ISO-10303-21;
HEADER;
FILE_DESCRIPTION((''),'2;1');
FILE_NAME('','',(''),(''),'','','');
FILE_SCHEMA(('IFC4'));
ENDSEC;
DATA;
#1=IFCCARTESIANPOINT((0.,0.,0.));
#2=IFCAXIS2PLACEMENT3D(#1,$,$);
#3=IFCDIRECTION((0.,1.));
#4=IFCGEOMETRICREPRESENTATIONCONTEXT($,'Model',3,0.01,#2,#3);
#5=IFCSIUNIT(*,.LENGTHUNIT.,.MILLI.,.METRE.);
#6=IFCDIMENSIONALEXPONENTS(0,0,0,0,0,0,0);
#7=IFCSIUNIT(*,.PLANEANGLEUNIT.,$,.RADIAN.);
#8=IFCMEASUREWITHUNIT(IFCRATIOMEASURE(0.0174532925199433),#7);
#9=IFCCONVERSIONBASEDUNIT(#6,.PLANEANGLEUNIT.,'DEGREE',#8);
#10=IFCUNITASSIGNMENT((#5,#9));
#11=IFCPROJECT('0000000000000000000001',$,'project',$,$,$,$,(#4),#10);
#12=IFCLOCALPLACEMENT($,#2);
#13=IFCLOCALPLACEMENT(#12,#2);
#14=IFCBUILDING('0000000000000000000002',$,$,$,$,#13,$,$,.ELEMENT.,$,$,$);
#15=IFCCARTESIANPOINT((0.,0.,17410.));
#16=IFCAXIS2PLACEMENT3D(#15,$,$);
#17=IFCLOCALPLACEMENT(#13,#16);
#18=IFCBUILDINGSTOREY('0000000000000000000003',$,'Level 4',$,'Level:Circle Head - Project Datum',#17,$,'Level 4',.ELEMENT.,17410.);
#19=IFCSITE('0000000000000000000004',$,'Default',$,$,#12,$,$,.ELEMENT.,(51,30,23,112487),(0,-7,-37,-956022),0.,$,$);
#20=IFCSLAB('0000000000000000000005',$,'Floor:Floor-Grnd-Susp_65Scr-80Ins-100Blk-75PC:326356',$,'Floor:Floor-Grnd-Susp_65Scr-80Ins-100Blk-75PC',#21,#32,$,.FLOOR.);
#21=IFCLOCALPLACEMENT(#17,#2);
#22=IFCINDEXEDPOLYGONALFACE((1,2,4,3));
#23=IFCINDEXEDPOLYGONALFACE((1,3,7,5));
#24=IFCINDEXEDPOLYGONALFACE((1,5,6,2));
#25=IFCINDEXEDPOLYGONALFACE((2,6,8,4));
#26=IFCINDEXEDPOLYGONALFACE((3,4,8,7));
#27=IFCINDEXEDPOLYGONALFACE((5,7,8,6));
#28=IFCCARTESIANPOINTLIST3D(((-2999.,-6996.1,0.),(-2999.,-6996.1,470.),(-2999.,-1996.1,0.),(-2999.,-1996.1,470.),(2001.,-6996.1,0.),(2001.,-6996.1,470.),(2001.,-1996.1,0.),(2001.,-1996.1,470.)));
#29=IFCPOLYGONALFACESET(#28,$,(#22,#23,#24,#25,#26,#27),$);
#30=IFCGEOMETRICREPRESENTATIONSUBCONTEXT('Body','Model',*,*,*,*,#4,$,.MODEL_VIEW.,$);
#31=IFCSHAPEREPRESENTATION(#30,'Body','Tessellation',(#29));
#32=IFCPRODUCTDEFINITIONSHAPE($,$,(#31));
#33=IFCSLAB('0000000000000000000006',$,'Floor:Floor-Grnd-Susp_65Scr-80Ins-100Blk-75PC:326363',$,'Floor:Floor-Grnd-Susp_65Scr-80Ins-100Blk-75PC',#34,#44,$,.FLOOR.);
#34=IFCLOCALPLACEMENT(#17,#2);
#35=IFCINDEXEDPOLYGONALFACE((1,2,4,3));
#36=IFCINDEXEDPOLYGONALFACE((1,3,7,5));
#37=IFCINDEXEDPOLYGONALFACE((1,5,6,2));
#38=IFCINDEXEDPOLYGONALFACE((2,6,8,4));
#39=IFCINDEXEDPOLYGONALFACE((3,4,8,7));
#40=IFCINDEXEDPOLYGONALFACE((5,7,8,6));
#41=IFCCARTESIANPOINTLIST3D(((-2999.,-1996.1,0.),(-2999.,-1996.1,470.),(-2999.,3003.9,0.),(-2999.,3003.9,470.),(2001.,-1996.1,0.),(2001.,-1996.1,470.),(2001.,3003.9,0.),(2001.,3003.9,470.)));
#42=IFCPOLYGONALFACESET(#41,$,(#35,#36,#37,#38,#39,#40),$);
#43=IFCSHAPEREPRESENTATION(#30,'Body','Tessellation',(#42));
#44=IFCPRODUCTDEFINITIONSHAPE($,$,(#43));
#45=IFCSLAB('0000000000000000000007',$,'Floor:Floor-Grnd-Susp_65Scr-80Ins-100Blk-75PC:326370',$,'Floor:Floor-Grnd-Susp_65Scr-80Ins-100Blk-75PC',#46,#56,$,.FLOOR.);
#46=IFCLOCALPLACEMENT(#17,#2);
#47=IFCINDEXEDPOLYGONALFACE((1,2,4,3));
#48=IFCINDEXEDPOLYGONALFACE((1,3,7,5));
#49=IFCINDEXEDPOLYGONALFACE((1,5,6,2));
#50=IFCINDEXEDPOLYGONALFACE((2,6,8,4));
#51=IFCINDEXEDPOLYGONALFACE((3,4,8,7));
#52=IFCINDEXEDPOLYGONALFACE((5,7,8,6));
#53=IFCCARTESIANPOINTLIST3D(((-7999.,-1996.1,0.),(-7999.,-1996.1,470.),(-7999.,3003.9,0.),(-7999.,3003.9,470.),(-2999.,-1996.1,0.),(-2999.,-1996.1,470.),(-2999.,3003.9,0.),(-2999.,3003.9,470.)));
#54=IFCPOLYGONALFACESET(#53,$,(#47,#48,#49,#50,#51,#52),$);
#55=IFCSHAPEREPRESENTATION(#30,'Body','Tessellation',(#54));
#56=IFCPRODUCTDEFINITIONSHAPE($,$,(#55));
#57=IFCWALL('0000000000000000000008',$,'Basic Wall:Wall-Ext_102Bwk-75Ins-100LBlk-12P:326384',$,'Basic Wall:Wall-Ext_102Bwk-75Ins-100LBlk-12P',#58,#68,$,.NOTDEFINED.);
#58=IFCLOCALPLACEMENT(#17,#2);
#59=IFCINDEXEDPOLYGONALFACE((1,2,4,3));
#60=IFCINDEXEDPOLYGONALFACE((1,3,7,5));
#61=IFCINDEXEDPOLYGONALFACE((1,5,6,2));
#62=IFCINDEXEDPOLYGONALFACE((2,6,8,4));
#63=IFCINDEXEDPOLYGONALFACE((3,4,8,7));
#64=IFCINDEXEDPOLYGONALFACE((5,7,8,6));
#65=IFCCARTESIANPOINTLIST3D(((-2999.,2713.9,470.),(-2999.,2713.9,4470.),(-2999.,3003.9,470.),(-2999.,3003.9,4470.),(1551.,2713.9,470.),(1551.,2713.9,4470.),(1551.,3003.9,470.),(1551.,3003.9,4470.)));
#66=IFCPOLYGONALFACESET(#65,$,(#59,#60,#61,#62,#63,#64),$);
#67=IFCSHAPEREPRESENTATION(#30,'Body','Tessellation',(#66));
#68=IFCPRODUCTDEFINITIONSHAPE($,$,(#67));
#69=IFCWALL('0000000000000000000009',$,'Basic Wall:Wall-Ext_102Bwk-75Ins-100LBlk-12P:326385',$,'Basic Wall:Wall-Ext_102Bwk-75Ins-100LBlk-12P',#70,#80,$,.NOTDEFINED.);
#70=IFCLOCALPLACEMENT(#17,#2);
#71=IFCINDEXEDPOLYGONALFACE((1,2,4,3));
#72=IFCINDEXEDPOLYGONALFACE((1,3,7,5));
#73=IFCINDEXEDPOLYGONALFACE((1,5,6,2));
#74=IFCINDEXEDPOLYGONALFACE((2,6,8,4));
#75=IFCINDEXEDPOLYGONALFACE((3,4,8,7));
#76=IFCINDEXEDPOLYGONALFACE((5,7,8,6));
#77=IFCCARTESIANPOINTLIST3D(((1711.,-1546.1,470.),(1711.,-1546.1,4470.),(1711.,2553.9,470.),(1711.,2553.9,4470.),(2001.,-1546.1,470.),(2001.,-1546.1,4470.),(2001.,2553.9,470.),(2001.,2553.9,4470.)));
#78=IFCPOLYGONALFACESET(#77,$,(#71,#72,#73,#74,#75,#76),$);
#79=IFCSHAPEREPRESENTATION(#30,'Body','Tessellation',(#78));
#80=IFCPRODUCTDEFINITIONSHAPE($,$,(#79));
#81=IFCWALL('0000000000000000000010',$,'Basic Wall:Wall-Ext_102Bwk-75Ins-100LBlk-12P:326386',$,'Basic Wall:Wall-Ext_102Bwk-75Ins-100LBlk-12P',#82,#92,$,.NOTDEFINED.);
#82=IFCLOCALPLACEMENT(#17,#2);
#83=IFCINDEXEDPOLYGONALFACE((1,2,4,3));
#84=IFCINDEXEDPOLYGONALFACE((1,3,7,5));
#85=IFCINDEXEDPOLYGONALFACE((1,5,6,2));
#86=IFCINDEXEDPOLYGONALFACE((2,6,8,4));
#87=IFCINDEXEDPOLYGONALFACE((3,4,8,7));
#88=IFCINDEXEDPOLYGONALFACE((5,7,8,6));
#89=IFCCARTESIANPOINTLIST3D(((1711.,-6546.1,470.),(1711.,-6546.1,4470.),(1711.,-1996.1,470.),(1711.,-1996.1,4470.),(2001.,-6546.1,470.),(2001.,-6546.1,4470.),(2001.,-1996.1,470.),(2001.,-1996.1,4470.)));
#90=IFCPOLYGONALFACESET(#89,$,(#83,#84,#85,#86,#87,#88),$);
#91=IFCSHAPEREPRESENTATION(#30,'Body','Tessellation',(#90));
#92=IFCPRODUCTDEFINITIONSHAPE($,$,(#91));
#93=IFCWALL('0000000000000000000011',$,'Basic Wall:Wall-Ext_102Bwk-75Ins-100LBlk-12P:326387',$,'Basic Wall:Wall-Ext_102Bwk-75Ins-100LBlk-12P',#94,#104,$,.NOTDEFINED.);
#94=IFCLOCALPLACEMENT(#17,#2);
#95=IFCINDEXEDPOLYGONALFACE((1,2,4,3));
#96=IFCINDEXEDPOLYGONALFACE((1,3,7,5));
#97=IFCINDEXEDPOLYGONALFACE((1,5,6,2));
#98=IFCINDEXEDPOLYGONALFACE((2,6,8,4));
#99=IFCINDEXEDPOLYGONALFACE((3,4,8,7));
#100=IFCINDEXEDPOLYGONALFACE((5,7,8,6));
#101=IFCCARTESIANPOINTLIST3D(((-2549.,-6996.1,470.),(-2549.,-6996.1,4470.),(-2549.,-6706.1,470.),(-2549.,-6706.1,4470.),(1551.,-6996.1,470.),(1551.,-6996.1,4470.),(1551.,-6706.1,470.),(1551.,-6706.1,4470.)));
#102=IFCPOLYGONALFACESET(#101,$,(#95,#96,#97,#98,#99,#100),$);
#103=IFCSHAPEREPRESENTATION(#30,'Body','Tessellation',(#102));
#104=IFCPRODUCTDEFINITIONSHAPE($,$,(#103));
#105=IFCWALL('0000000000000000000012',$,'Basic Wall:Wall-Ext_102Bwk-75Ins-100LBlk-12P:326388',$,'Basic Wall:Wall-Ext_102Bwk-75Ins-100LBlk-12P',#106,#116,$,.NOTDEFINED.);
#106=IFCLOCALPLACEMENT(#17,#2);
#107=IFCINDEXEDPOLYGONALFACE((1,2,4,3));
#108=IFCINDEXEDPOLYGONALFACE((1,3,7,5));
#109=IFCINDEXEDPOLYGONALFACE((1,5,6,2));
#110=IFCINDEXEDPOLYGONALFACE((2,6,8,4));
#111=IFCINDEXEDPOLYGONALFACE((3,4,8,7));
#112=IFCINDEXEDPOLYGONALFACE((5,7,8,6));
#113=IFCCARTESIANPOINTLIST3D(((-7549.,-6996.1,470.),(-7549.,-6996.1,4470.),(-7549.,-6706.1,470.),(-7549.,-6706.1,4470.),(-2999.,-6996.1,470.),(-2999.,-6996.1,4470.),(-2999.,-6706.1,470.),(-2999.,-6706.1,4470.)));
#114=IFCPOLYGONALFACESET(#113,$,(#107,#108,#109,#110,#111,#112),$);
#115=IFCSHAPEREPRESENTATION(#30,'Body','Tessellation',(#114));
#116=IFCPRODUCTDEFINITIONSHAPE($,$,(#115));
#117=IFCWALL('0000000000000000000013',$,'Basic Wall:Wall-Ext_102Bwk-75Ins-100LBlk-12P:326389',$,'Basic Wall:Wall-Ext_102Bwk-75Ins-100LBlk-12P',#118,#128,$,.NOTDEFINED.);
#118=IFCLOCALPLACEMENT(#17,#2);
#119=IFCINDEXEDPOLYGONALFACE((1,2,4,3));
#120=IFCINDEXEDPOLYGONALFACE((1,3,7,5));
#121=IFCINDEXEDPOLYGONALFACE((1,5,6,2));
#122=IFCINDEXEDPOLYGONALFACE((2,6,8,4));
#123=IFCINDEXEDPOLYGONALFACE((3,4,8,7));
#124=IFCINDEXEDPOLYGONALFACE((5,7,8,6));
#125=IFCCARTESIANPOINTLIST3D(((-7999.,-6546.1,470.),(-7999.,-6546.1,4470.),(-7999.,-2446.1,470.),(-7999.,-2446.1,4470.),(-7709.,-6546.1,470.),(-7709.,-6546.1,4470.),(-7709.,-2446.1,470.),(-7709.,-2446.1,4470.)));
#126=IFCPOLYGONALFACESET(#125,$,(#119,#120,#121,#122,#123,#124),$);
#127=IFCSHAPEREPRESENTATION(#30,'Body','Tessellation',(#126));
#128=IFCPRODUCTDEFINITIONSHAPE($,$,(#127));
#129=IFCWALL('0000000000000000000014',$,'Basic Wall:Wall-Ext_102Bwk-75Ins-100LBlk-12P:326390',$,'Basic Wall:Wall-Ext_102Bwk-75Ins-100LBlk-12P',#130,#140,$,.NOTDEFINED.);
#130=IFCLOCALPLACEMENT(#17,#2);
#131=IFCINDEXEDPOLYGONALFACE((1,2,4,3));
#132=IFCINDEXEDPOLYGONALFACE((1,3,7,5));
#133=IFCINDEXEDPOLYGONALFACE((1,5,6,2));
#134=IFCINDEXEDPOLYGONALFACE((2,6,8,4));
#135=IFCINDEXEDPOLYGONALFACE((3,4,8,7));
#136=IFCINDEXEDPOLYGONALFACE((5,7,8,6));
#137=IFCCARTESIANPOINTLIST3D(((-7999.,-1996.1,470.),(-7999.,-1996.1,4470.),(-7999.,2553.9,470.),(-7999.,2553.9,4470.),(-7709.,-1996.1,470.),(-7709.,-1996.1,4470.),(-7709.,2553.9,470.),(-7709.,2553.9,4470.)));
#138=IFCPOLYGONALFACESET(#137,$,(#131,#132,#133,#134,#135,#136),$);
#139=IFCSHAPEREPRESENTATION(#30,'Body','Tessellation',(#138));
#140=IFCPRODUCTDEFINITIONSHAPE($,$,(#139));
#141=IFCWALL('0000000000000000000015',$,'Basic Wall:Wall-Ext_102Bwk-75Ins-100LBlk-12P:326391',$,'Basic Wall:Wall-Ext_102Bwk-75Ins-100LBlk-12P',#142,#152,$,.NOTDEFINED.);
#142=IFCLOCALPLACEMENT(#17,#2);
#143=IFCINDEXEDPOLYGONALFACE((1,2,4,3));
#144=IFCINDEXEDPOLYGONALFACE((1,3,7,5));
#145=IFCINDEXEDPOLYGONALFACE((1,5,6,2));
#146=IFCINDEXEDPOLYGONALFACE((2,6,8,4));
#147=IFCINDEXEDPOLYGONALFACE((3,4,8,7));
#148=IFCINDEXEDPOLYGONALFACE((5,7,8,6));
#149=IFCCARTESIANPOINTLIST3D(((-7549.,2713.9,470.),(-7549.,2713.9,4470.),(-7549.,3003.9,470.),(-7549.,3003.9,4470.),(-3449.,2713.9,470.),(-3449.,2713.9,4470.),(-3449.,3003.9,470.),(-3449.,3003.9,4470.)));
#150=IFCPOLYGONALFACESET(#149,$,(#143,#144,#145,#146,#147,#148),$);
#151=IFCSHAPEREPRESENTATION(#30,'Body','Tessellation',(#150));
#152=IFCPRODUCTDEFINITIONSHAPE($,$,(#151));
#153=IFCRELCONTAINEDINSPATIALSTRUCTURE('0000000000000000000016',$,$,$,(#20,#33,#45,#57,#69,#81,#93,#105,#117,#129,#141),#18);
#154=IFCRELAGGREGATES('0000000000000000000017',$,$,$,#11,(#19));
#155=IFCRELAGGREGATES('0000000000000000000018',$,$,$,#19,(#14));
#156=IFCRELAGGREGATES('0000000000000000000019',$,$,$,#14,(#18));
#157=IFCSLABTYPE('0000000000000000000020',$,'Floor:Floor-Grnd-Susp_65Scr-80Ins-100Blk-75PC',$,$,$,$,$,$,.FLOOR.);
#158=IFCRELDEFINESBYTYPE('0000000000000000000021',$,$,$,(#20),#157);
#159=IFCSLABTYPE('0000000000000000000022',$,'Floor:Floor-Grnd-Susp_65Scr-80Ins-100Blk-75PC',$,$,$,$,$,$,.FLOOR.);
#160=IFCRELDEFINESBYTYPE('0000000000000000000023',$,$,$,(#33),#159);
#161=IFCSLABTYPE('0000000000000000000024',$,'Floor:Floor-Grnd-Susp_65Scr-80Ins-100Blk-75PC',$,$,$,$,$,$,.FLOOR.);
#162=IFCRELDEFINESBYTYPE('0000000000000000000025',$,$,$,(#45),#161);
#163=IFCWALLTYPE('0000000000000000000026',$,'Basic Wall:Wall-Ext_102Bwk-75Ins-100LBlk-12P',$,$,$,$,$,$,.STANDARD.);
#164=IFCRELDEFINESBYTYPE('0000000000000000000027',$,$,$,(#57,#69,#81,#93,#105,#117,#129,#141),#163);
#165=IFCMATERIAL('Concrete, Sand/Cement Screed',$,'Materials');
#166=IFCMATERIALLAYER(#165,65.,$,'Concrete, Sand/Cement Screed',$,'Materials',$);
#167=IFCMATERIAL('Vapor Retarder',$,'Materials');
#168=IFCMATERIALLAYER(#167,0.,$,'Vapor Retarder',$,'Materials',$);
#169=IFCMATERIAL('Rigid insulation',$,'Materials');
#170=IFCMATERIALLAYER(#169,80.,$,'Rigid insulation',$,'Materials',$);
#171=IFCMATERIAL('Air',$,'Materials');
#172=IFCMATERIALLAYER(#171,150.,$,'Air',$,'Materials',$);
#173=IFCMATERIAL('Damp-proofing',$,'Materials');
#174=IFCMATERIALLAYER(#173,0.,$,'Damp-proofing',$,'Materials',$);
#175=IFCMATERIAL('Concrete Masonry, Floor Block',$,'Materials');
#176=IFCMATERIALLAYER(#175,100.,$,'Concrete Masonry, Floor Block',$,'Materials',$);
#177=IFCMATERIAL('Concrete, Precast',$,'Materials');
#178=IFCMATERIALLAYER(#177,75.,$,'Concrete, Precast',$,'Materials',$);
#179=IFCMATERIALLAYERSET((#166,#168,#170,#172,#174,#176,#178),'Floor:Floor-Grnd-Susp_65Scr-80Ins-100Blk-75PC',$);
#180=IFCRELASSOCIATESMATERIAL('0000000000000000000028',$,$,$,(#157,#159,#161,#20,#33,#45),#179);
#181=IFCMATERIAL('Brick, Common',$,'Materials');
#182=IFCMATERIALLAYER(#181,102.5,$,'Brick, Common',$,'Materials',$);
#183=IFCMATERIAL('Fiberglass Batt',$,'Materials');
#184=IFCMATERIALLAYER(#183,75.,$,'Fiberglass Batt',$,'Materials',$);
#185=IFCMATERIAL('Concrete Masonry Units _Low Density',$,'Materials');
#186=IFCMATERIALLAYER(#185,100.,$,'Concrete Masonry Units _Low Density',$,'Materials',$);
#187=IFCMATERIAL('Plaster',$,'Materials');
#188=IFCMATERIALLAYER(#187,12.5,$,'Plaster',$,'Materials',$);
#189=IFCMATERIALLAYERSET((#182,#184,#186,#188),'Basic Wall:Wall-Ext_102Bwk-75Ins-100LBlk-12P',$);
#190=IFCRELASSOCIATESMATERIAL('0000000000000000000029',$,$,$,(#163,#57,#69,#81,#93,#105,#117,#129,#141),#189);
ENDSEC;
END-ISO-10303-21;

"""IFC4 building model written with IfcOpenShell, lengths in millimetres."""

from ifc_helpers import new_model, entity, si_unit, converted_unit, direction, frame, frame_2d, origin, origin_2d_with_axis, place, context, subcontext, project, spatial, rectangle, extrude, material, layer, layer_set, layer_usage, type_object, element, save


model = new_model("IFC4")

# Units and contexts
model_context = context("Model", 3, precision=0.01, world=origin(), true_north=direction((0.0, 1.0)))
body_context = subcontext(model_context, "Body", "Model", "MODEL_VIEW")
ifc_project = project(units=[si_unit("LENGTHUNIT", "METRE", prefix="MILLI"), converted_unit("PLANEANGLEUNIT", "DEGREE", entity("IfcRatioMeasure", 0.0174532925199433), si_unit("PLANEANGLEUNIT", "RADIAN"), dimensions=[0, 0, 0, 0, 0, 0, 0])], contexts=[model_context])

# Site, building, storey
site_placement = place(None, origin())
site = spatial("IfcSite", under=ifc_project, at=site_placement, Name="Default", CompositionType="ELEMENT", RefLatitude=(51, 30, 23, 112487), RefLongitude=(0, -7, -37, -956022), RefElevation=0.0)
building_placement = place(site_placement, origin())
building = spatial("IfcBuilding", under=site, at=building_placement, CompositionType="ELEMENT")
storey_placement = place(building_placement, frame((0.0, 0.0, 17410.0)))
storey = spatial("IfcBuildingStorey", under=building, at=storey_placement, Name="Level 4", ObjectType="Level:Circle Head - Project Datum", LongName="Level 4", CompositionType="ELEMENT", Elevation=17410.0)

# Slabs
ifc_material_1 = material(Name="Concrete, Sand/Cement Screed", Category="Materials")
ifc_layer_1 = layer(ifc_material_1, 65.0, Name="Concrete, Sand/Cement Screed", Category="Materials")
ifc_material_2 = material(Name="Vapor Retarder", Category="Materials")
ifc_layer_2 = layer(ifc_material_2, 0.0, Name="Vapor Retarder", Category="Materials")
ifc_material_3 = material(Name="Rigid insulation", Category="Materials")
ifc_layer_3 = layer(ifc_material_3, 80.0, Name="Rigid insulation", Category="Materials")
ifc_material_4 = material(Name="Air", Category="Materials")
ifc_layer_4 = layer(ifc_material_4, 150.0, Name="Air", Category="Materials")
ifc_material_5 = material(Name="Damp-proofing", Category="Materials")
ifc_layer_5 = layer(ifc_material_5, 0.0, Name="Damp-proofing", Category="Materials")
ifc_material_6 = material(Name="Concrete Masonry, Floor Block", Category="Materials")
ifc_layer_6 = layer(ifc_material_6, 100.0, Name="Concrete Masonry, Floor Block", Category="Materials")
ifc_material_7 = material(Name="Concrete, Precast", Category="Materials")
ifc_layer_7 = layer(ifc_material_7, 75.0, Name="Concrete, Precast", Category="Materials")
ifc_layer_set_1 = layer_set([ifc_layer_1, ifc_layer_2, ifc_layer_3, ifc_layer_4, ifc_layer_5, ifc_layer_6, ifc_layer_7], Name="Floor:Floor-Grnd-Susp_65Scr-80Ins-100Blk-75PC")
ifc_layer_usage_1 = layer_usage(ifc_layer_set_1, "AXIS3", "POSITIVE", 0.0)
slab_type_1 = type_object("IfcSlabType", Name="Floor:Floor-Grnd-Susp_65Scr-80Ins-100Blk-75PC", PredefinedType="FLOOR", material=ifc_layer_set_1)
slab_1_placement = place(storey_placement, origin())
element("IfcSlab", 1, at=slab_1_placement, inside=storey, type_object=slab_type_1, material=ifc_layer_usage_1, Name="Floor:Floor-Grnd-Susp_65Scr-80Ins-100Blk-75PC:326356", ObjectType="Floor:Floor-Grnd-Susp_65Scr-80Ins-100Blk-75PC", PredefinedType="FLOOR", context=body_context, shape_type="SweptSolid", body=[
    extrude(rectangle(XDim=5000.0, YDim=5000.0, at=frame_2d((0.0, 0.0), x_axis=(1.0, 0.0))), frame((-499.0, -4496.1, 470.0), z_axis=(0.0, 0.0, -1.0), x_axis=(0.0, 1.0, 0.0)), (0.0, 0.0, 1.0), 470.0),
])
ifc_layer_usage_2 = layer_usage(ifc_layer_set_1, "AXIS3", "POSITIVE", 0.0)
slab_type_2 = type_object("IfcSlabType", Name="Floor:Floor-Grnd-Susp_65Scr-80Ins-100Blk-75PC", PredefinedType="FLOOR", material=ifc_layer_set_1)
slab_2_placement = place(storey_placement, origin())
element("IfcSlab", 2, at=slab_2_placement, inside=storey, type_object=slab_type_2, material=ifc_layer_usage_2, Name="Floor:Floor-Grnd-Susp_65Scr-80Ins-100Blk-75PC:326363", ObjectType="Floor:Floor-Grnd-Susp_65Scr-80Ins-100Blk-75PC", PredefinedType="FLOOR", context=body_context, shape_type="SweptSolid", body=[
    extrude(rectangle(XDim=5000.0, YDim=5000.0, at=origin_2d_with_axis()), frame((-499.0, 503.9, 470.0), z_axis=(0.0, 0.0, -1.0), x_axis=(0.0, 1.0, 0.0)), (0.0, 0.0, 1.0), 470.0),
])
ifc_layer_usage_3 = layer_usage(ifc_layer_set_1, "AXIS3", "POSITIVE", 0.0)
slab_type_3 = type_object("IfcSlabType", Name="Floor:Floor-Grnd-Susp_65Scr-80Ins-100Blk-75PC", PredefinedType="FLOOR", material=ifc_layer_set_1)
slab_3_placement = place(storey_placement, origin())
element("IfcSlab", 3, at=slab_3_placement, inside=storey, type_object=slab_type_3, material=ifc_layer_usage_3, Name="Floor:Floor-Grnd-Susp_65Scr-80Ins-100Blk-75PC:326370", ObjectType="Floor:Floor-Grnd-Susp_65Scr-80Ins-100Blk-75PC", PredefinedType="FLOOR", context=body_context, shape_type="SweptSolid", body=[
    extrude(rectangle(XDim=5000.0, YDim=5000.0, at=origin_2d_with_axis()), frame((-5499.0, 503.9, 470.0), z_axis=(0.0, 0.0, -1.0), x_axis=(0.0, 1.0, 0.0)), (0.0, 0.0, 1.0), 470.0),
])

# Walls
ifc_material_8 = material(Name="Brick, Common", Category="Materials")
ifc_layer_8 = layer(ifc_material_8, 102.5, Name="Brick, Common", Category="Materials")
ifc_material_9 = material(Name="Fiberglass Batt", Category="Materials")
ifc_layer_9 = layer(ifc_material_9, 75.0, Name="Fiberglass Batt", Category="Materials")
ifc_material_10 = material(Name="Concrete Masonry Units _Low Density", Category="Materials")
ifc_layer_10 = layer(ifc_material_10, 100.0, Name="Concrete Masonry Units _Low Density", Category="Materials")
ifc_material_11 = material(Name="Plaster", Category="Materials")
ifc_layer_11 = layer(ifc_material_11, 12.5, Name="Plaster", Category="Materials")
ifc_layer_set_2 = layer_set([ifc_layer_8, ifc_layer_9, ifc_layer_10, ifc_layer_11], Name="Basic Wall:Wall-Ext_102Bwk-75Ins-100LBlk-12P")
ifc_layer_usage_4 = layer_usage(ifc_layer_set_2, "AXIS2", "NEGATIVE", 145.0)
wall_type = type_object("IfcWallType", Name="Basic Wall:Wall-Ext_102Bwk-75Ins-100LBlk-12P", PredefinedType="STANDARD", material=ifc_layer_set_2)
wall_1_placement = place(storey_placement, frame((-2999.0, 2858.9, 470.0)))
element("IfcWall", 4, at=wall_1_placement, inside=storey, type_object=wall_type, material=ifc_layer_usage_4, Name="Basic Wall:Wall-Ext_102Bwk-75Ins-100LBlk-12P:326384", ObjectType="Basic Wall:Wall-Ext_102Bwk-75Ins-100LBlk-12P", PredefinedType="NOTDEFINED", context=body_context, shape_type="SweptSolid", body=[
    extrude(rectangle(XDim=4550.0, YDim=290.0, at=frame_2d((2275.0, 0.0), x_axis=(-1.0, 0.0))), origin(), (0.0, 0.0, 1.0), 4000.0),
])
ifc_layer_usage_5 = layer_usage(ifc_layer_set_2, "AXIS2", "NEGATIVE", 145.0)
wall_2_placement = place(storey_placement, frame((1856.0, 2553.9, 470.0), z_axis=(0.0, 0.0, 1.0), x_axis=(0.0, -1.0, 0.0)))
element("IfcWall", 5, at=wall_2_placement, inside=storey, type_object=wall_type, material=ifc_layer_usage_5, Name="Basic Wall:Wall-Ext_102Bwk-75Ins-100LBlk-12P:326385", ObjectType="Basic Wall:Wall-Ext_102Bwk-75Ins-100LBlk-12P", PredefinedType="NOTDEFINED", context=body_context, shape_type="SweptSolid", body=[
    extrude(rectangle(XDim=4100.0, YDim=290.0, at=frame_2d((2050.0, 0.0), x_axis=(-1.0, 0.0))), origin(), (0.0, 0.0, 1.0), 4000.0),
])
ifc_layer_usage_6 = layer_usage(ifc_layer_set_2, "AXIS2", "NEGATIVE", 145.0)
wall_3_placement = place(storey_placement, frame((1856.0, -1996.1, 470.0), z_axis=(0.0, 0.0, 1.0), x_axis=(0.0, -1.0, 0.0)))
element("IfcWall", 6, at=wall_3_placement, inside=storey, type_object=wall_type, material=ifc_layer_usage_6, Name="Basic Wall:Wall-Ext_102Bwk-75Ins-100LBlk-12P:326386", ObjectType="Basic Wall:Wall-Ext_102Bwk-75Ins-100LBlk-12P", PredefinedType="NOTDEFINED", context=body_context, shape_type="SweptSolid", body=[
    extrude(rectangle(XDim=4550.0, YDim=290.0, at=frame_2d((2275.0, 0.0), x_axis=(-1.0, 0.0))), origin(), (0.0, 0.0, 1.0), 4000.0),
])
ifc_layer_usage_7 = layer_usage(ifc_layer_set_2, "AXIS2", "NEGATIVE", 145.0)
wall_4_placement = place(storey_placement, frame((1551.0, -6851.1, 470.0), z_axis=(0.0, 0.0, 1.0), x_axis=(-1.0, 0.0, 0.0)))
element("IfcWall", 7, at=wall_4_placement, inside=storey, type_object=wall_type, material=ifc_layer_usage_7, Name="Basic Wall:Wall-Ext_102Bwk-75Ins-100LBlk-12P:326387", ObjectType="Basic Wall:Wall-Ext_102Bwk-75Ins-100LBlk-12P", PredefinedType="NOTDEFINED", context=body_context, shape_type="SweptSolid", body=[
    extrude(rectangle(XDim=4100.0, YDim=290.0, at=frame_2d((2050.0, 0.0), x_axis=(-1.0, 0.0))), origin(), (0.0, 0.0, 1.0), 4000.0),
])
ifc_layer_usage_8 = layer_usage(ifc_layer_set_2, "AXIS2", "NEGATIVE", 145.0)
wall_5_placement = place(storey_placement, frame((-2999.0, -6851.1, 470.0), z_axis=(0.0, 0.0, 1.0), x_axis=(-1.0, 0.0, 0.0)))
element("IfcWall", 8, at=wall_5_placement, inside=storey, type_object=wall_type, material=ifc_layer_usage_8, Name="Basic Wall:Wall-Ext_102Bwk-75Ins-100LBlk-12P:326388", ObjectType="Basic Wall:Wall-Ext_102Bwk-75Ins-100LBlk-12P", PredefinedType="NOTDEFINED", context=body_context, shape_type="SweptSolid", body=[
    extrude(rectangle(XDim=4550.0, YDim=290.0, at=frame_2d((2275.0, 0.0), x_axis=(-1.0, 0.0))), origin(), (0.0, 0.0, 1.0), 4000.0),
])
ifc_layer_usage_9 = layer_usage(ifc_layer_set_2, "AXIS2", "NEGATIVE", 145.0)
wall_6_placement = place(storey_placement, frame((-7854.0, -6546.1, 470.0), z_axis=(0.0, 0.0, 1.0), x_axis=(0.0, 1.0, 0.0)))
element("IfcWall", 9, at=wall_6_placement, inside=storey, type_object=wall_type, material=ifc_layer_usage_9, Name="Basic Wall:Wall-Ext_102Bwk-75Ins-100LBlk-12P:326389", ObjectType="Basic Wall:Wall-Ext_102Bwk-75Ins-100LBlk-12P", PredefinedType="NOTDEFINED", context=body_context, shape_type="SweptSolid", body=[
    extrude(rectangle(XDim=4100.0, YDim=290.0, at=frame_2d((2050.0, 0.0), x_axis=(-1.0, 0.0))), origin(), (0.0, 0.0, 1.0), 4000.0),
])
ifc_layer_usage_10 = layer_usage(ifc_layer_set_2, "AXIS2", "NEGATIVE", 145.0)
wall_7_placement = place(storey_placement, frame((-7854.0, -1996.1, 470.0), z_axis=(0.0, 0.0, 1.0), x_axis=(0.0, 1.0, 0.0)))
element("IfcWall", 10, at=wall_7_placement, inside=storey, type_object=wall_type, material=ifc_layer_usage_10, Name="Basic Wall:Wall-Ext_102Bwk-75Ins-100LBlk-12P:326390", ObjectType="Basic Wall:Wall-Ext_102Bwk-75Ins-100LBlk-12P", PredefinedType="NOTDEFINED", context=body_context, shape_type="SweptSolid", body=[
    extrude(rectangle(XDim=4550.0, YDim=290.0, at=frame_2d((2275.0, 0.0), x_axis=(-1.0, 0.0))), origin(), (0.0, 0.0, 1.0), 4000.0),
])
ifc_layer_usage_11 = layer_usage(ifc_layer_set_2, "AXIS2", "NEGATIVE", 145.0)
wall_8_placement = place(storey_placement, frame((-7549.0, 2858.9, 470.0)))
element("IfcWall", 11, at=wall_8_placement, inside=storey, type_object=wall_type, material=ifc_layer_usage_11, Name="Basic Wall:Wall-Ext_102Bwk-75Ins-100LBlk-12P:326391", ObjectType="Basic Wall:Wall-Ext_102Bwk-75Ins-100LBlk-12P", PredefinedType="NOTDEFINED", context=body_context, shape_type="SweptSolid", body=[
    extrude(rectangle(XDim=4100.0, YDim=290.0, at=frame_2d((2050.0, 0.0), x_axis=(-1.0, 0.0))), origin(), (0.0, 0.0, 1.0), 4000.0),
])

save(model, "model.ifc")
